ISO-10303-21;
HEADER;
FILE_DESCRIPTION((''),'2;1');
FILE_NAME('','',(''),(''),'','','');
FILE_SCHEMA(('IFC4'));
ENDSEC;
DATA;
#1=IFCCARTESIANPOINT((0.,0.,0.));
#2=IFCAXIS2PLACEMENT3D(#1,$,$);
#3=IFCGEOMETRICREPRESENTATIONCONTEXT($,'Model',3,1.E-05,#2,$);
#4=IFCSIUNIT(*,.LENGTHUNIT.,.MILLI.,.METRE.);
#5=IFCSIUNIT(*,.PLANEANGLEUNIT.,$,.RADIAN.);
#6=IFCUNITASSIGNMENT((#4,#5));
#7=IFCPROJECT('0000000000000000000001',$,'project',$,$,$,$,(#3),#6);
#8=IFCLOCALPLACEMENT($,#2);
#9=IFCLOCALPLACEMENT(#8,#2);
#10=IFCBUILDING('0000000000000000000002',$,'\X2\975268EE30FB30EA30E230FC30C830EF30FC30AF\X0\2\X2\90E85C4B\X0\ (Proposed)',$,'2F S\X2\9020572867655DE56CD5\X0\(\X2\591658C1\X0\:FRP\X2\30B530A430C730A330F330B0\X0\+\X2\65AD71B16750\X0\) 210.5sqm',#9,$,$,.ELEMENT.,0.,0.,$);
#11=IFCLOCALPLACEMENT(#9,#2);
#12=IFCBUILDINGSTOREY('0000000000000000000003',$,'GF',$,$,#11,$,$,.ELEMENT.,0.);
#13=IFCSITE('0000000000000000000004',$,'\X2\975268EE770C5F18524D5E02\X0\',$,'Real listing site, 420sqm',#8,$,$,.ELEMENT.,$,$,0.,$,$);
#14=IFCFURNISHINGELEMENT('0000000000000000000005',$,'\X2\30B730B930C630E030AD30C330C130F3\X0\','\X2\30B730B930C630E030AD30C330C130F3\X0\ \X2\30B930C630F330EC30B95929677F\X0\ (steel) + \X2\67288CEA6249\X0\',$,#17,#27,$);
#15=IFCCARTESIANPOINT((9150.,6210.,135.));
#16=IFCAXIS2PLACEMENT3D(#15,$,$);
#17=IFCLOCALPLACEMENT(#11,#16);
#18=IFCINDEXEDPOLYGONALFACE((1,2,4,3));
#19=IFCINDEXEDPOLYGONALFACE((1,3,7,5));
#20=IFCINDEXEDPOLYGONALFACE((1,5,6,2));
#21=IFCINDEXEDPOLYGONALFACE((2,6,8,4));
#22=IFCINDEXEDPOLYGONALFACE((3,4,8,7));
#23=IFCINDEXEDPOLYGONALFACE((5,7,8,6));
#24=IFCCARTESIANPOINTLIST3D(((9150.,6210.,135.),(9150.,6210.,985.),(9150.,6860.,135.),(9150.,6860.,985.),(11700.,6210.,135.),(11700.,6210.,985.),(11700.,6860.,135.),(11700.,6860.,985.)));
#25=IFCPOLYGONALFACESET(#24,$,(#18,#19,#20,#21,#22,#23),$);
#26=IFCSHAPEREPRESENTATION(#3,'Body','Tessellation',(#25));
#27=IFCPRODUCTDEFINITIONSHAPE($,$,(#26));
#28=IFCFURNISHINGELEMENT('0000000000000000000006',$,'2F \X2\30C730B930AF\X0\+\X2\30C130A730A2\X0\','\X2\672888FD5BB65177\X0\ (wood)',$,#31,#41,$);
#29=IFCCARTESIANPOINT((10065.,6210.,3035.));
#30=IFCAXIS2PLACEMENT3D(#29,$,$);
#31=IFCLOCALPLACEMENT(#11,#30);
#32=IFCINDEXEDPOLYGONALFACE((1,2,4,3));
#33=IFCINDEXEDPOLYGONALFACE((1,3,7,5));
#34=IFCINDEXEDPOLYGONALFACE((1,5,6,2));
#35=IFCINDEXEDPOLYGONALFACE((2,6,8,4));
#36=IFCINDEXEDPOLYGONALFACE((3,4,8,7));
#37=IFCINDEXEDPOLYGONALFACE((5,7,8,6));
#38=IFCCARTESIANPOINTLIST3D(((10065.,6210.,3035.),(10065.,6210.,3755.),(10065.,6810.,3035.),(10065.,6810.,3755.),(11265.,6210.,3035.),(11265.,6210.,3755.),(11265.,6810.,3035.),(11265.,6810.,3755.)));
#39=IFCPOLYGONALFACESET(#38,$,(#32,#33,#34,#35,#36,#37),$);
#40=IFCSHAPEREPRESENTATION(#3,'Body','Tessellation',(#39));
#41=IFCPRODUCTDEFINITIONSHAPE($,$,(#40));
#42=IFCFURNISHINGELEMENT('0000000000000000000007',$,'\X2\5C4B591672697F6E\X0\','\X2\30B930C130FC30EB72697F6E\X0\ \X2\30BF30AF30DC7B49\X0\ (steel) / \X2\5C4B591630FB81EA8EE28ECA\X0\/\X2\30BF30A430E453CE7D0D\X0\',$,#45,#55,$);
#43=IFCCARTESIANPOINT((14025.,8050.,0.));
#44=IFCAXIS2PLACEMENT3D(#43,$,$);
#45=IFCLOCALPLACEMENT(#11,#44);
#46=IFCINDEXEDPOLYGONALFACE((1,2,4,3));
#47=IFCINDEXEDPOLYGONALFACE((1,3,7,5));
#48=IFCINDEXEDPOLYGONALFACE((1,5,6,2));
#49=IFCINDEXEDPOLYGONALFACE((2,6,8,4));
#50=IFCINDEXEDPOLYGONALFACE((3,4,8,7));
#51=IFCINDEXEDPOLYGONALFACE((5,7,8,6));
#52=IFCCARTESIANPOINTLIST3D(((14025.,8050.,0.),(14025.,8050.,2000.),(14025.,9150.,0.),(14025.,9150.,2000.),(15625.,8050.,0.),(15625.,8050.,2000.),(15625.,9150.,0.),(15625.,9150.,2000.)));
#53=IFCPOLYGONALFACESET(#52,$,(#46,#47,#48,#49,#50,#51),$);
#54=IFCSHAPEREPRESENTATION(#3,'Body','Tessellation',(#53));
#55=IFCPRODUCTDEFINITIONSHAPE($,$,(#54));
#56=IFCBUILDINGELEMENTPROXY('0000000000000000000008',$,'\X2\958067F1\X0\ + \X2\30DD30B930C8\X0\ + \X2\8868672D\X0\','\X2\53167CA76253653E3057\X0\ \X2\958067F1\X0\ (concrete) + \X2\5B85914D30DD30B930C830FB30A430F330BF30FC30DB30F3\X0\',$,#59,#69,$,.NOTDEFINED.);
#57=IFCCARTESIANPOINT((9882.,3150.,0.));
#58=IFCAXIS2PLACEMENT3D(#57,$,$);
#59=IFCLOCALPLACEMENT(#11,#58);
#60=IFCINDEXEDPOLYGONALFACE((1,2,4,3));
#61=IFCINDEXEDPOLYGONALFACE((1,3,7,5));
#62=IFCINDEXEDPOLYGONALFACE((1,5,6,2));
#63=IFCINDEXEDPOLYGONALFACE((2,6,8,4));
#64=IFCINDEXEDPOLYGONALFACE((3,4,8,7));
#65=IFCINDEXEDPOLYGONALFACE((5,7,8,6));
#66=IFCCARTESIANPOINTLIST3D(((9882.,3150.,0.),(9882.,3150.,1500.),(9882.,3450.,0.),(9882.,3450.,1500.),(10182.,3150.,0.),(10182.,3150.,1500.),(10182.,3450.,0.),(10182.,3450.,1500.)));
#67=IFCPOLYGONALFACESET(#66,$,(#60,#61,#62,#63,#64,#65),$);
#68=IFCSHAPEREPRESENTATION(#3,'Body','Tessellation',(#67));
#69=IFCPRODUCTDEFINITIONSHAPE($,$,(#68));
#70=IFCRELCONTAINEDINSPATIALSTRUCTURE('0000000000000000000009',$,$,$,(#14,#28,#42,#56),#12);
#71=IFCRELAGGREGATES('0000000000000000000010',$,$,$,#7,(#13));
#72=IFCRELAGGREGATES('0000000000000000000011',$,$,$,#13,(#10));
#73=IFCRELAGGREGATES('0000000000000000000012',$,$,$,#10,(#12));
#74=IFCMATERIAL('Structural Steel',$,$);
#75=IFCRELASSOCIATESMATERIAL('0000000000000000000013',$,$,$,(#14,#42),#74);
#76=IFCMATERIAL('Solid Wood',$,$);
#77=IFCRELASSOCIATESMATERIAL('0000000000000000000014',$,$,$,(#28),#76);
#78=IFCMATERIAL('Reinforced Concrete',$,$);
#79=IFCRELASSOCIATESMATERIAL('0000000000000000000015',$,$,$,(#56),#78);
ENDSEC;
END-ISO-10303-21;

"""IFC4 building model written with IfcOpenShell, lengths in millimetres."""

from ifc_helpers import new_model, si_unit, frame, frame_2d, origin, place, context, project, spatial, rectangle, extrude, material, element, save


model = new_model("IFC4")

# Units and contexts
model_context = context("Model", 3, precision=1e-05, world=origin())
ifc_project = project(units=[si_unit("LENGTHUNIT", "METRE", prefix="MILLI"), si_unit("PLANEANGLEUNIT", "RADIAN")], contexts=[model_context])

# Site, building, storey
site_placement = place(None, origin())
site = spatial("IfcSite", under=ifc_project, at=site_placement, Name="青森県弘前市", ObjectType="Real listing site, 420sqm", CompositionType="ELEMENT", RefElevation=0.0)
building_placement = place(site_placement, origin())
building = spatial("IfcBuilding", under=site, at=building_placement, Name="青森・リモートワーク2部屋 (Proposed)", ObjectType="2F S造在来工法(外壁:FRPサイディング+断熱材) 210.5sqm", CompositionType="ELEMENT", ElevationOfRefHeight=0.0, ElevationOfTerrain=0.0)
storey_placement = place(building_placement, origin())
storey = spatial("IfcBuildingStorey", under=building, at=storey_placement, Name="GF", CompositionType="ELEMENT", Elevation=0.0)

# Shared definitions
ifc_material_1 = material(Name="Solid Wood")

# Shared definitions
ifc_material_2 = material(Name="Reinforced Concrete")

# Shared definitions
ifc_material_3 = material(Name="Structural Steel")

# Furnishing elements
furnishing_1_placement = place(storey_placement, frame((9150.0, 6210.0, 135.0)))
element("IfcFurnishingElement", 1, at=furnishing_1_placement, inside=storey, material=ifc_material_3, Name="システムキッチン", Description="システムキッチン ステンレス天板 (steel) + 木質扉", context=model_context, shape_type="SweptSolid", body=[
    extrude(rectangle(XDim=2550.0, YDim=650.0, at=frame_2d((1275.0, 325.0))), frame((9150.0, 6210.0, 135.0)), (0.0, 0.0, 1.0), 850.0),
])
furnishing_2_placement = place(storey_placement, frame((10065.0, 6210.0, 3035.0)))
element("IfcFurnishingElement", 2, at=furnishing_2_placement, inside=storey, material=ifc_material_1, Name="2F デスク+チェア", Description="木製家具 (wood)", context=model_context, shape_type="SweptSolid", body=[
    extrude(rectangle(XDim=1200.0, YDim=600.0, at=frame_2d((600.0, 300.0))), frame((10065.0, 6210.0, 3035.0)), (0.0, 0.0, 1.0), 720.0),
])
furnishing_3_placement = place(storey_placement, frame((14025.0, 8050.0, 0.0)))
element("IfcFurnishingElement", 3, at=furnishing_3_placement, inside=storey, material=ifc_material_3, Name="屋外物置", Description="スチール物置 タクボ等 (steel) / 屋外・自転車/タイヤ収納", context=model_context, shape_type="SweptSolid", body=[
    extrude(rectangle(XDim=1600.0, YDim=1100.0, at=frame_2d((800.0, 550.0))), frame((14025.0, 8050.0, 0.0)), (0.0, 0.0, 1.0), 2000.0),
])

# Building element proxy
proxy_placement = place(storey_placement, frame((9882.0, 3150.0, 0.0)))
element("IfcBuildingElementProxy", 4, at=proxy_placement, inside=storey, material=ifc_material_2, Name="門柱 + ポスト + 表札", Description="化粧打放し 門柱 (concrete) + 宅配ポスト・インターホン", PredefinedType="NOTDEFINED", context=model_context, shape_type="SweptSolid", body=[
    extrude(rectangle(XDim=300.0, YDim=300.0, at=frame_2d((150.0, 150.0))), frame((9882.0, 3150.0, 0.0)), (0.0, 0.0, 1.0), 1500.0),
])

save(model, "model.ifc")
